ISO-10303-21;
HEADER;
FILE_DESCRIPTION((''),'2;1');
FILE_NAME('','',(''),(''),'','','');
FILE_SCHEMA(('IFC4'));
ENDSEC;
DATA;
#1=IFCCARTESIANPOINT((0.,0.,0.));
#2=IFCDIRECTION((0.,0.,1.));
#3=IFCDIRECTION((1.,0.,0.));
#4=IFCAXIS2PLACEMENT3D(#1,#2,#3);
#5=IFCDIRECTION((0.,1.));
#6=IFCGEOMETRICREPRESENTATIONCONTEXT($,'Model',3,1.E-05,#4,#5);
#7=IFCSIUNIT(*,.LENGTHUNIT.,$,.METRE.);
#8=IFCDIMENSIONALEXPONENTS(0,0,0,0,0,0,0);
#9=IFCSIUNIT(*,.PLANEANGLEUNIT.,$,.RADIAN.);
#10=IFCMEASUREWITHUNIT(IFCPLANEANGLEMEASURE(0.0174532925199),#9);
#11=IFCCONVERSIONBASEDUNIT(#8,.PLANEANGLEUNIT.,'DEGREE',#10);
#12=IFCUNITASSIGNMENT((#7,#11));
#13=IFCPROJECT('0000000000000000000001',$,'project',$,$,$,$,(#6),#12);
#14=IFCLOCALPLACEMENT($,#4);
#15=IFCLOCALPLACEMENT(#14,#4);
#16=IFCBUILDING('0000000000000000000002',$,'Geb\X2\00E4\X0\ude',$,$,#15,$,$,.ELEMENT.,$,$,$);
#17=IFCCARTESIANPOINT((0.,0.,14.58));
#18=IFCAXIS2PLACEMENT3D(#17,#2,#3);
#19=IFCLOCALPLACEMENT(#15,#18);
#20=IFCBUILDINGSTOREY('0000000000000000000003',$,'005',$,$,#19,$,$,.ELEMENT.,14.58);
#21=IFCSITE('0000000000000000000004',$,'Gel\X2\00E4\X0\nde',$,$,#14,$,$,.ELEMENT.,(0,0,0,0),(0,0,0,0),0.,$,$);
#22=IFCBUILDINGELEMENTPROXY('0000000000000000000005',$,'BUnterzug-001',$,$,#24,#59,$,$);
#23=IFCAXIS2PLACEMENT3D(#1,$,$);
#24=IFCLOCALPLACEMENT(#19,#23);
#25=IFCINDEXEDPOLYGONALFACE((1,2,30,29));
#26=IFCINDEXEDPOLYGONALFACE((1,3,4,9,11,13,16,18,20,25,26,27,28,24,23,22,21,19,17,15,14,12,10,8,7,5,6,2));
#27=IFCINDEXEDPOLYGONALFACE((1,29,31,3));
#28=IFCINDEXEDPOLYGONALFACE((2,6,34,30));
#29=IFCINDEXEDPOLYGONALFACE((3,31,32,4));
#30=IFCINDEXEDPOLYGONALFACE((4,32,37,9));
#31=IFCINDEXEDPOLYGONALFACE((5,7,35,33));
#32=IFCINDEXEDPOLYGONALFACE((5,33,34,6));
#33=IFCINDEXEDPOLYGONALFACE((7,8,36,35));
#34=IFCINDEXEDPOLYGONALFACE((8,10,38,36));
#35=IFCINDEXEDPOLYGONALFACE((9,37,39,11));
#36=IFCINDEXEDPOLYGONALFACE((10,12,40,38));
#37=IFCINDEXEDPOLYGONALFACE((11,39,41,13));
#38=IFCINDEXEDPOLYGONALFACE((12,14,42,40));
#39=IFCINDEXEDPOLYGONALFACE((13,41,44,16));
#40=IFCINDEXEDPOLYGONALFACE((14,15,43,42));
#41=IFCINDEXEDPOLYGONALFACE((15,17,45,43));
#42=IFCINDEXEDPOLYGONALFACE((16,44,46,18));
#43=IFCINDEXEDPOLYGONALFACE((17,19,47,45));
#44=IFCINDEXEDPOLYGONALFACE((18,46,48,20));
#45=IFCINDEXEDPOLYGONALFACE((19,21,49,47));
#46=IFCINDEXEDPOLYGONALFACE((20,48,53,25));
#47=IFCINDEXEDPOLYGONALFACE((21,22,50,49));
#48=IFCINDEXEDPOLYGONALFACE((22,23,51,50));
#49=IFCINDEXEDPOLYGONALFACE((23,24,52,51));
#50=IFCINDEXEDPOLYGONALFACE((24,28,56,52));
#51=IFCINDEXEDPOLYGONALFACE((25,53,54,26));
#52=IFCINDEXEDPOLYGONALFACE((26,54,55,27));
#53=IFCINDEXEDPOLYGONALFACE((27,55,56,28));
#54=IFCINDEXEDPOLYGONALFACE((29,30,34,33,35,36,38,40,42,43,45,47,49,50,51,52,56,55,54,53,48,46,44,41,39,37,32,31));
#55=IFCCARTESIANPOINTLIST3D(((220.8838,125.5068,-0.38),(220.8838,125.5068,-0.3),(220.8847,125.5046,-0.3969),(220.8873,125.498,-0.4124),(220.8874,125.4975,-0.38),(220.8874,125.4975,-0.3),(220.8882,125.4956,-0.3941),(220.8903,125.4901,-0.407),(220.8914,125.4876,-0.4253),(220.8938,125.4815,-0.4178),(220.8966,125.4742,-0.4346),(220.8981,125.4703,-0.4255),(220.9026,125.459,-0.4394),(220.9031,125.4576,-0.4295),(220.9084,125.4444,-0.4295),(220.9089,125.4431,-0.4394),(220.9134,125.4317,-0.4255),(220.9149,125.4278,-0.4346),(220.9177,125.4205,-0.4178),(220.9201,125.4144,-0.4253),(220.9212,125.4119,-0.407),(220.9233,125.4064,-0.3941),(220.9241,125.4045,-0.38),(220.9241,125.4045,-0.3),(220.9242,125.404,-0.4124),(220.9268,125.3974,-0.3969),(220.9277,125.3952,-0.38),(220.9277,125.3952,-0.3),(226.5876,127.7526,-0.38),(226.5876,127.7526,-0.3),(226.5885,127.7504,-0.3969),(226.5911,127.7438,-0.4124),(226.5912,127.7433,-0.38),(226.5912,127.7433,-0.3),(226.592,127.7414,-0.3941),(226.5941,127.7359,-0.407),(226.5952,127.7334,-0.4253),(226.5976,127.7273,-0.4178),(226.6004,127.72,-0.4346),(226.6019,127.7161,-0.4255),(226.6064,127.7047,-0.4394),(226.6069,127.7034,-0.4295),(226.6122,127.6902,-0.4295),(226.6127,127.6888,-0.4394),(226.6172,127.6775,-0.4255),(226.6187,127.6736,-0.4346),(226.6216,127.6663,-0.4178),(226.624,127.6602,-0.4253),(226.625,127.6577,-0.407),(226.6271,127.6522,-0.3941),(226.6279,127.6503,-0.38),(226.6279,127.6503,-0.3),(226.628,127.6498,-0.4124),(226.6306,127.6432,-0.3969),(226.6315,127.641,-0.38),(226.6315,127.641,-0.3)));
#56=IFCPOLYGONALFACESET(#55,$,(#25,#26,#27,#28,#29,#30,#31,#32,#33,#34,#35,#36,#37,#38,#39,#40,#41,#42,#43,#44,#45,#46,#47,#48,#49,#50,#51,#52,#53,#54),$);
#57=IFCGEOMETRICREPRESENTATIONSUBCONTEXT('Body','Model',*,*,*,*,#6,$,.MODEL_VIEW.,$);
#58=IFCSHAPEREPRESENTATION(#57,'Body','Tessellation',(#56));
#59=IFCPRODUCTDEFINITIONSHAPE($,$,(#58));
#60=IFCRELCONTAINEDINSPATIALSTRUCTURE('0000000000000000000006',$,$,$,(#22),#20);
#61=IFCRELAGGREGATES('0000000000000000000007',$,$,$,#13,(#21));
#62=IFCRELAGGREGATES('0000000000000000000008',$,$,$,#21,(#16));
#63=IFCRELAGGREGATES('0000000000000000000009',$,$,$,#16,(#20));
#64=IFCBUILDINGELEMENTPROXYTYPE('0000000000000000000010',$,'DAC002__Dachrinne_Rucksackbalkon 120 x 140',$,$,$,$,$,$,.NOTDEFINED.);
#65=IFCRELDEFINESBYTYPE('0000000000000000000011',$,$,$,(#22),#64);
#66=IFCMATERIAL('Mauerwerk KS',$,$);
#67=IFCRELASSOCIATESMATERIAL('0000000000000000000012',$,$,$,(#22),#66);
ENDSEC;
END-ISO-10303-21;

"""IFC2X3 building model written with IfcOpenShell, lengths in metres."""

from ifc_helpers import new_model, entity, si_unit, converted_unit, point, direction, frame, frame_2d, origin_with_axes, place, context, subcontext, project, spatial, polyline, circle_curve, parameter, trimmed, segment, composite_curve, outline, extrude, material, type_object, element, save


model = new_model("IFC2X3")

# Units and contexts
model_context = context("Model", 3, precision=1e-05, world=origin_with_axes(), true_north=direction((0.0, 1.0)))
body_context = subcontext(model_context, "Body", "Model", "MODEL_VIEW")
ifc_project = project(units=[si_unit("LENGTHUNIT", "METRE"), converted_unit("PLANEANGLEUNIT", "DEGREE", entity("IfcPlaneAngleMeasure", 0.0174532925199), si_unit("PLANEANGLEUNIT", "RADIAN"), dimensions=[0, 0, 0, 0, 0, 0, 0])], contexts=[model_context])

# Site, building, storey
site_placement = place(None, origin_with_axes())
site = spatial("IfcSite", under=ifc_project, at=site_placement, Name="Gelände", CompositionType="ELEMENT", RefLatitude=(0, 0, 0, 0), RefLongitude=(0, 0, 0, 0), RefElevation=0.0)
building_placement = place(site_placement, origin_with_axes())
building = spatial("IfcBuilding", under=site, at=building_placement, Name="Gebäude", CompositionType="ELEMENT")
storey_placement = place(building_placement, frame((0.0, 0.0, 14.58), z_axis=(0.0, 0.0, 1.0), x_axis=(1.0, 0.0, 0.0)))
storey = spatial("IfcBuildingStorey", under=building, at=storey_placement, Name="005", CompositionType="ELEMENT", Elevation=14.58)

# Building element proxy
ifc_material_1 = material(Name="Mauerwerk KS")
building_element_proxy_type = type_object("IfcBuildingElementProxyType", Name="DAC002__Dachrinne_Rucksackbalkon 120 x 140", PredefinedType="NOTDEFINED")
proxy_placement = place(storey_placement, frame((226.5876, 127.7526, -0.3), z_axis=(0.0, 0.0, 1.0), x_axis=(-0.36636, 0.930473, 0.0)))
element("IfcBuildingElementProxy", 1, at=proxy_placement, inside=storey, type_object=building_element_proxy_type, material=ifc_material_1, Name="BUnterzug-001", context=body_context, shape_type="SweptSolid", body=[
    extrude(outline(composite_curve([segment(polyline([(-0.12, 0.0), (-0.12, -0.08)]), True, "CONTINUOUS"), segment(trimmed(circle_curve(frame_2d((-0.06, -0.08), x_axis=(-1.0, 0.0)), 0.06), [point((-0.12, -0.08)), parameter(0.0)], [point((0.0, -0.08)), parameter(180.0)], True, "CARTESIAN"), True, "CONTINUOUS"), segment(polyline([(0.0, -0.08), (0.0, 0.0), (-0.01, 0.0), (-0.01, -0.08)]), True, "CONTINUOUS"), segment(trimmed(circle_curve(frame_2d((-0.06, -0.08), x_axis=(-1.0, 0.0)), 0.05), [point((-0.01, -0.08)), parameter(180.0)], [point((-0.11, -0.08)), parameter(0.0)], False, "CARTESIAN"), True, "CONTINUOUS"), segment(polyline([(-0.11, -0.08), (-0.11, 0.0), (-0.12, 0.0)]), True, "CONTINUOUS")], self_intersect=False)), frame((0.0, 6.13, 0.0), z_axis=(0.0, -1.0, 0.0), x_axis=(1.0, 0.0, 0.0)), (0.0, 0.0, 1.0), 6.13),
])

save(model, "model.ifc")
